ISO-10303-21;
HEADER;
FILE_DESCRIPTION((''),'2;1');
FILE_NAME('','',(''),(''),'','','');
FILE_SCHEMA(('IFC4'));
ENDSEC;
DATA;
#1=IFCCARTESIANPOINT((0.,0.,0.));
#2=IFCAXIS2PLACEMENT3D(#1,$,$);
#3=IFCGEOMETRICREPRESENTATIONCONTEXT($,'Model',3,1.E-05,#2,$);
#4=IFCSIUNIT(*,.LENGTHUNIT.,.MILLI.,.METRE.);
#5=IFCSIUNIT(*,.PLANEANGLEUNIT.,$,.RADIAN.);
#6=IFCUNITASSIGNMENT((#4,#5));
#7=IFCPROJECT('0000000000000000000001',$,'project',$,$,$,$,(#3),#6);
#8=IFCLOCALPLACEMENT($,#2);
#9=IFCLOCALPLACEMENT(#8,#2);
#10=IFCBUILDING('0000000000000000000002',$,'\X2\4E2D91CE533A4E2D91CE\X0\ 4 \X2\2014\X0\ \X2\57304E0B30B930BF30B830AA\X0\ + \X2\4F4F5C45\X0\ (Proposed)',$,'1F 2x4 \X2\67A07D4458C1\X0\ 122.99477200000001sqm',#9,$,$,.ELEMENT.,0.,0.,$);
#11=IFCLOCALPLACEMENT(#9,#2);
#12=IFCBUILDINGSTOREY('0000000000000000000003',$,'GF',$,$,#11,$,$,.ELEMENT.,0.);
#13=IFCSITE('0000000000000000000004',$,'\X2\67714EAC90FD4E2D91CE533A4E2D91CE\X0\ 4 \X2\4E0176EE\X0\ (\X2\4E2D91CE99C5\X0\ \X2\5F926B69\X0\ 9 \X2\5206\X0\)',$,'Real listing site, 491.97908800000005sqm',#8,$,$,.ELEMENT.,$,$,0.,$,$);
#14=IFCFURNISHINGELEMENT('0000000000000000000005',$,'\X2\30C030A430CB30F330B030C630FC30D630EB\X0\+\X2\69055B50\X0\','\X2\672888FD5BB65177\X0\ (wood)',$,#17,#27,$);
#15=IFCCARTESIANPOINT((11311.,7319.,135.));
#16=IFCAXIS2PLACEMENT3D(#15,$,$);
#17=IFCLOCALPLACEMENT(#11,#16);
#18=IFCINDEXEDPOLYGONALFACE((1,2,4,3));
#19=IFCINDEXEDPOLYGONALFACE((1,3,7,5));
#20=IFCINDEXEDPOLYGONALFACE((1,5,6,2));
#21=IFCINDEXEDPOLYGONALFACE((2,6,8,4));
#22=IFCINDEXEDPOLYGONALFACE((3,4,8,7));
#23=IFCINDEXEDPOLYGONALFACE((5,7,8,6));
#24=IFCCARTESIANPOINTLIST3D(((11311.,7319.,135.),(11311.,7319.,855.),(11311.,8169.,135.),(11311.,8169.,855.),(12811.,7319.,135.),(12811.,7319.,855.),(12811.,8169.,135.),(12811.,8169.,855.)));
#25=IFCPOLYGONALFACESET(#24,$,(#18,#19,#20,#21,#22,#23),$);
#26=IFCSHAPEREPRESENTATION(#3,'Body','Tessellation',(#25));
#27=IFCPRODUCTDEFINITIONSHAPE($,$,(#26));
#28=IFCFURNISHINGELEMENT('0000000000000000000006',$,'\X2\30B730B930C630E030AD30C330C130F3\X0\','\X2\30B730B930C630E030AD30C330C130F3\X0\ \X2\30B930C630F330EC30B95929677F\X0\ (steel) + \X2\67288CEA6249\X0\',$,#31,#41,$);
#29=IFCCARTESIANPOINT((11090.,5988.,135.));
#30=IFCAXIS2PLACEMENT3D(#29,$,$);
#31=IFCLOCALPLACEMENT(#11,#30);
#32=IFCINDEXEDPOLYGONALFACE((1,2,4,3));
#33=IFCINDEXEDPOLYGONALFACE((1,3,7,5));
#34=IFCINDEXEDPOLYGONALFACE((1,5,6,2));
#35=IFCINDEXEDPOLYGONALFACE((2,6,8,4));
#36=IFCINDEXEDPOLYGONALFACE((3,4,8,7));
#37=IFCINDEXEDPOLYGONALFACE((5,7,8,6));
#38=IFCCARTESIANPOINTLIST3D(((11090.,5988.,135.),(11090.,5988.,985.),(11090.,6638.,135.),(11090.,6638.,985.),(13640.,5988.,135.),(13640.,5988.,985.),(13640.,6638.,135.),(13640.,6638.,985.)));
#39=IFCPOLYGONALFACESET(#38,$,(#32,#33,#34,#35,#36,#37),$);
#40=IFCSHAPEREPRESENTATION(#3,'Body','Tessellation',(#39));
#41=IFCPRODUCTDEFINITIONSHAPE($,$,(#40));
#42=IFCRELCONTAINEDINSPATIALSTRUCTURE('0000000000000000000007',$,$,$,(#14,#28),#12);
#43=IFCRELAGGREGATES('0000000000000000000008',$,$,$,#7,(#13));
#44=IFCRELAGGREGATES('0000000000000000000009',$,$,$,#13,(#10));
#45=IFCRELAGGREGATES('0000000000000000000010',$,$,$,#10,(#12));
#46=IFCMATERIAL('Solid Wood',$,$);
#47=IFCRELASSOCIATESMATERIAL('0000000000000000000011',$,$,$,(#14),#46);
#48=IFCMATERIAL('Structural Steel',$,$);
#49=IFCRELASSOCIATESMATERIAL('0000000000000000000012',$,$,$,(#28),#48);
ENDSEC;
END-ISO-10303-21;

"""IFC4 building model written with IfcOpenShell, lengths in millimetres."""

from ifc_helpers import new_model, si_unit, frame, frame_2d, origin, place, context, project, spatial, rectangle, extrude, material, element, save


model = new_model("IFC4")

# Units and contexts
model_context = context("Model", 3, precision=1e-05, world=origin())
ifc_project = project(units=[si_unit("LENGTHUNIT", "METRE", prefix="MILLI"), si_unit("PLANEANGLEUNIT", "RADIAN")], contexts=[model_context])

# Site, building, storey
site_placement = place(None, origin())
site = spatial("IfcSite", under=ifc_project, at=site_placement, Name="東京都中野区中野 4 丁目 (中野駅 徒歩 9 分)", ObjectType="Real listing site, 491.97908800000005sqm", CompositionType="ELEMENT", RefElevation=0.0)
building_placement = place(site_placement, origin())
building = spatial("IfcBuilding", under=site, at=building_placement, Name="中野区中野 4 — 地下スタジオ + 住居 (Proposed)", ObjectType="1F 2x4 枠組壁 122.99477200000001sqm", CompositionType="ELEMENT", ElevationOfRefHeight=0.0, ElevationOfTerrain=0.0)
storey_placement = place(building_placement, origin())
storey = spatial("IfcBuildingStorey", under=building, at=storey_placement, Name="GF", CompositionType="ELEMENT", Elevation=0.0)

# Shared definitions
ifc_material_1 = material(Name="Solid Wood")

# Shared definitions
ifc_material_2 = material(Name="Structural Steel")

# Furnishing elements
furnishing_1_placement = place(storey_placement, frame((11311.0, 7319.0, 135.0)))
element("IfcFurnishingElement", 1, at=furnishing_1_placement, inside=storey, material=ifc_material_1, Name="ダイニングテーブル+椅子", Description="木製家具 (wood)", context=model_context, shape_type="SweptSolid", body=[
    extrude(rectangle(XDim=1500.0, YDim=850.0, at=frame_2d((750.0, 425.0))), frame((11311.0, 7319.0, 135.0)), (0.0, 0.0, 1.0), 720.0),
])
furnishing_2_placement = place(storey_placement, frame((11090.0, 5988.0, 135.0)))
element("IfcFurnishingElement", 2, at=furnishing_2_placement, inside=storey, material=ifc_material_2, Name="システムキッチン", Description="システムキッチン ステンレス天板 (steel) + 木質扉", context=model_context, shape_type="SweptSolid", body=[
    extrude(rectangle(XDim=2550.0, YDim=650.0, at=frame_2d((1275.0, 325.0))), frame((11090.0, 5988.0, 135.0)), (0.0, 0.0, 1.0), 850.0),
])

save(model, "model.ifc")
